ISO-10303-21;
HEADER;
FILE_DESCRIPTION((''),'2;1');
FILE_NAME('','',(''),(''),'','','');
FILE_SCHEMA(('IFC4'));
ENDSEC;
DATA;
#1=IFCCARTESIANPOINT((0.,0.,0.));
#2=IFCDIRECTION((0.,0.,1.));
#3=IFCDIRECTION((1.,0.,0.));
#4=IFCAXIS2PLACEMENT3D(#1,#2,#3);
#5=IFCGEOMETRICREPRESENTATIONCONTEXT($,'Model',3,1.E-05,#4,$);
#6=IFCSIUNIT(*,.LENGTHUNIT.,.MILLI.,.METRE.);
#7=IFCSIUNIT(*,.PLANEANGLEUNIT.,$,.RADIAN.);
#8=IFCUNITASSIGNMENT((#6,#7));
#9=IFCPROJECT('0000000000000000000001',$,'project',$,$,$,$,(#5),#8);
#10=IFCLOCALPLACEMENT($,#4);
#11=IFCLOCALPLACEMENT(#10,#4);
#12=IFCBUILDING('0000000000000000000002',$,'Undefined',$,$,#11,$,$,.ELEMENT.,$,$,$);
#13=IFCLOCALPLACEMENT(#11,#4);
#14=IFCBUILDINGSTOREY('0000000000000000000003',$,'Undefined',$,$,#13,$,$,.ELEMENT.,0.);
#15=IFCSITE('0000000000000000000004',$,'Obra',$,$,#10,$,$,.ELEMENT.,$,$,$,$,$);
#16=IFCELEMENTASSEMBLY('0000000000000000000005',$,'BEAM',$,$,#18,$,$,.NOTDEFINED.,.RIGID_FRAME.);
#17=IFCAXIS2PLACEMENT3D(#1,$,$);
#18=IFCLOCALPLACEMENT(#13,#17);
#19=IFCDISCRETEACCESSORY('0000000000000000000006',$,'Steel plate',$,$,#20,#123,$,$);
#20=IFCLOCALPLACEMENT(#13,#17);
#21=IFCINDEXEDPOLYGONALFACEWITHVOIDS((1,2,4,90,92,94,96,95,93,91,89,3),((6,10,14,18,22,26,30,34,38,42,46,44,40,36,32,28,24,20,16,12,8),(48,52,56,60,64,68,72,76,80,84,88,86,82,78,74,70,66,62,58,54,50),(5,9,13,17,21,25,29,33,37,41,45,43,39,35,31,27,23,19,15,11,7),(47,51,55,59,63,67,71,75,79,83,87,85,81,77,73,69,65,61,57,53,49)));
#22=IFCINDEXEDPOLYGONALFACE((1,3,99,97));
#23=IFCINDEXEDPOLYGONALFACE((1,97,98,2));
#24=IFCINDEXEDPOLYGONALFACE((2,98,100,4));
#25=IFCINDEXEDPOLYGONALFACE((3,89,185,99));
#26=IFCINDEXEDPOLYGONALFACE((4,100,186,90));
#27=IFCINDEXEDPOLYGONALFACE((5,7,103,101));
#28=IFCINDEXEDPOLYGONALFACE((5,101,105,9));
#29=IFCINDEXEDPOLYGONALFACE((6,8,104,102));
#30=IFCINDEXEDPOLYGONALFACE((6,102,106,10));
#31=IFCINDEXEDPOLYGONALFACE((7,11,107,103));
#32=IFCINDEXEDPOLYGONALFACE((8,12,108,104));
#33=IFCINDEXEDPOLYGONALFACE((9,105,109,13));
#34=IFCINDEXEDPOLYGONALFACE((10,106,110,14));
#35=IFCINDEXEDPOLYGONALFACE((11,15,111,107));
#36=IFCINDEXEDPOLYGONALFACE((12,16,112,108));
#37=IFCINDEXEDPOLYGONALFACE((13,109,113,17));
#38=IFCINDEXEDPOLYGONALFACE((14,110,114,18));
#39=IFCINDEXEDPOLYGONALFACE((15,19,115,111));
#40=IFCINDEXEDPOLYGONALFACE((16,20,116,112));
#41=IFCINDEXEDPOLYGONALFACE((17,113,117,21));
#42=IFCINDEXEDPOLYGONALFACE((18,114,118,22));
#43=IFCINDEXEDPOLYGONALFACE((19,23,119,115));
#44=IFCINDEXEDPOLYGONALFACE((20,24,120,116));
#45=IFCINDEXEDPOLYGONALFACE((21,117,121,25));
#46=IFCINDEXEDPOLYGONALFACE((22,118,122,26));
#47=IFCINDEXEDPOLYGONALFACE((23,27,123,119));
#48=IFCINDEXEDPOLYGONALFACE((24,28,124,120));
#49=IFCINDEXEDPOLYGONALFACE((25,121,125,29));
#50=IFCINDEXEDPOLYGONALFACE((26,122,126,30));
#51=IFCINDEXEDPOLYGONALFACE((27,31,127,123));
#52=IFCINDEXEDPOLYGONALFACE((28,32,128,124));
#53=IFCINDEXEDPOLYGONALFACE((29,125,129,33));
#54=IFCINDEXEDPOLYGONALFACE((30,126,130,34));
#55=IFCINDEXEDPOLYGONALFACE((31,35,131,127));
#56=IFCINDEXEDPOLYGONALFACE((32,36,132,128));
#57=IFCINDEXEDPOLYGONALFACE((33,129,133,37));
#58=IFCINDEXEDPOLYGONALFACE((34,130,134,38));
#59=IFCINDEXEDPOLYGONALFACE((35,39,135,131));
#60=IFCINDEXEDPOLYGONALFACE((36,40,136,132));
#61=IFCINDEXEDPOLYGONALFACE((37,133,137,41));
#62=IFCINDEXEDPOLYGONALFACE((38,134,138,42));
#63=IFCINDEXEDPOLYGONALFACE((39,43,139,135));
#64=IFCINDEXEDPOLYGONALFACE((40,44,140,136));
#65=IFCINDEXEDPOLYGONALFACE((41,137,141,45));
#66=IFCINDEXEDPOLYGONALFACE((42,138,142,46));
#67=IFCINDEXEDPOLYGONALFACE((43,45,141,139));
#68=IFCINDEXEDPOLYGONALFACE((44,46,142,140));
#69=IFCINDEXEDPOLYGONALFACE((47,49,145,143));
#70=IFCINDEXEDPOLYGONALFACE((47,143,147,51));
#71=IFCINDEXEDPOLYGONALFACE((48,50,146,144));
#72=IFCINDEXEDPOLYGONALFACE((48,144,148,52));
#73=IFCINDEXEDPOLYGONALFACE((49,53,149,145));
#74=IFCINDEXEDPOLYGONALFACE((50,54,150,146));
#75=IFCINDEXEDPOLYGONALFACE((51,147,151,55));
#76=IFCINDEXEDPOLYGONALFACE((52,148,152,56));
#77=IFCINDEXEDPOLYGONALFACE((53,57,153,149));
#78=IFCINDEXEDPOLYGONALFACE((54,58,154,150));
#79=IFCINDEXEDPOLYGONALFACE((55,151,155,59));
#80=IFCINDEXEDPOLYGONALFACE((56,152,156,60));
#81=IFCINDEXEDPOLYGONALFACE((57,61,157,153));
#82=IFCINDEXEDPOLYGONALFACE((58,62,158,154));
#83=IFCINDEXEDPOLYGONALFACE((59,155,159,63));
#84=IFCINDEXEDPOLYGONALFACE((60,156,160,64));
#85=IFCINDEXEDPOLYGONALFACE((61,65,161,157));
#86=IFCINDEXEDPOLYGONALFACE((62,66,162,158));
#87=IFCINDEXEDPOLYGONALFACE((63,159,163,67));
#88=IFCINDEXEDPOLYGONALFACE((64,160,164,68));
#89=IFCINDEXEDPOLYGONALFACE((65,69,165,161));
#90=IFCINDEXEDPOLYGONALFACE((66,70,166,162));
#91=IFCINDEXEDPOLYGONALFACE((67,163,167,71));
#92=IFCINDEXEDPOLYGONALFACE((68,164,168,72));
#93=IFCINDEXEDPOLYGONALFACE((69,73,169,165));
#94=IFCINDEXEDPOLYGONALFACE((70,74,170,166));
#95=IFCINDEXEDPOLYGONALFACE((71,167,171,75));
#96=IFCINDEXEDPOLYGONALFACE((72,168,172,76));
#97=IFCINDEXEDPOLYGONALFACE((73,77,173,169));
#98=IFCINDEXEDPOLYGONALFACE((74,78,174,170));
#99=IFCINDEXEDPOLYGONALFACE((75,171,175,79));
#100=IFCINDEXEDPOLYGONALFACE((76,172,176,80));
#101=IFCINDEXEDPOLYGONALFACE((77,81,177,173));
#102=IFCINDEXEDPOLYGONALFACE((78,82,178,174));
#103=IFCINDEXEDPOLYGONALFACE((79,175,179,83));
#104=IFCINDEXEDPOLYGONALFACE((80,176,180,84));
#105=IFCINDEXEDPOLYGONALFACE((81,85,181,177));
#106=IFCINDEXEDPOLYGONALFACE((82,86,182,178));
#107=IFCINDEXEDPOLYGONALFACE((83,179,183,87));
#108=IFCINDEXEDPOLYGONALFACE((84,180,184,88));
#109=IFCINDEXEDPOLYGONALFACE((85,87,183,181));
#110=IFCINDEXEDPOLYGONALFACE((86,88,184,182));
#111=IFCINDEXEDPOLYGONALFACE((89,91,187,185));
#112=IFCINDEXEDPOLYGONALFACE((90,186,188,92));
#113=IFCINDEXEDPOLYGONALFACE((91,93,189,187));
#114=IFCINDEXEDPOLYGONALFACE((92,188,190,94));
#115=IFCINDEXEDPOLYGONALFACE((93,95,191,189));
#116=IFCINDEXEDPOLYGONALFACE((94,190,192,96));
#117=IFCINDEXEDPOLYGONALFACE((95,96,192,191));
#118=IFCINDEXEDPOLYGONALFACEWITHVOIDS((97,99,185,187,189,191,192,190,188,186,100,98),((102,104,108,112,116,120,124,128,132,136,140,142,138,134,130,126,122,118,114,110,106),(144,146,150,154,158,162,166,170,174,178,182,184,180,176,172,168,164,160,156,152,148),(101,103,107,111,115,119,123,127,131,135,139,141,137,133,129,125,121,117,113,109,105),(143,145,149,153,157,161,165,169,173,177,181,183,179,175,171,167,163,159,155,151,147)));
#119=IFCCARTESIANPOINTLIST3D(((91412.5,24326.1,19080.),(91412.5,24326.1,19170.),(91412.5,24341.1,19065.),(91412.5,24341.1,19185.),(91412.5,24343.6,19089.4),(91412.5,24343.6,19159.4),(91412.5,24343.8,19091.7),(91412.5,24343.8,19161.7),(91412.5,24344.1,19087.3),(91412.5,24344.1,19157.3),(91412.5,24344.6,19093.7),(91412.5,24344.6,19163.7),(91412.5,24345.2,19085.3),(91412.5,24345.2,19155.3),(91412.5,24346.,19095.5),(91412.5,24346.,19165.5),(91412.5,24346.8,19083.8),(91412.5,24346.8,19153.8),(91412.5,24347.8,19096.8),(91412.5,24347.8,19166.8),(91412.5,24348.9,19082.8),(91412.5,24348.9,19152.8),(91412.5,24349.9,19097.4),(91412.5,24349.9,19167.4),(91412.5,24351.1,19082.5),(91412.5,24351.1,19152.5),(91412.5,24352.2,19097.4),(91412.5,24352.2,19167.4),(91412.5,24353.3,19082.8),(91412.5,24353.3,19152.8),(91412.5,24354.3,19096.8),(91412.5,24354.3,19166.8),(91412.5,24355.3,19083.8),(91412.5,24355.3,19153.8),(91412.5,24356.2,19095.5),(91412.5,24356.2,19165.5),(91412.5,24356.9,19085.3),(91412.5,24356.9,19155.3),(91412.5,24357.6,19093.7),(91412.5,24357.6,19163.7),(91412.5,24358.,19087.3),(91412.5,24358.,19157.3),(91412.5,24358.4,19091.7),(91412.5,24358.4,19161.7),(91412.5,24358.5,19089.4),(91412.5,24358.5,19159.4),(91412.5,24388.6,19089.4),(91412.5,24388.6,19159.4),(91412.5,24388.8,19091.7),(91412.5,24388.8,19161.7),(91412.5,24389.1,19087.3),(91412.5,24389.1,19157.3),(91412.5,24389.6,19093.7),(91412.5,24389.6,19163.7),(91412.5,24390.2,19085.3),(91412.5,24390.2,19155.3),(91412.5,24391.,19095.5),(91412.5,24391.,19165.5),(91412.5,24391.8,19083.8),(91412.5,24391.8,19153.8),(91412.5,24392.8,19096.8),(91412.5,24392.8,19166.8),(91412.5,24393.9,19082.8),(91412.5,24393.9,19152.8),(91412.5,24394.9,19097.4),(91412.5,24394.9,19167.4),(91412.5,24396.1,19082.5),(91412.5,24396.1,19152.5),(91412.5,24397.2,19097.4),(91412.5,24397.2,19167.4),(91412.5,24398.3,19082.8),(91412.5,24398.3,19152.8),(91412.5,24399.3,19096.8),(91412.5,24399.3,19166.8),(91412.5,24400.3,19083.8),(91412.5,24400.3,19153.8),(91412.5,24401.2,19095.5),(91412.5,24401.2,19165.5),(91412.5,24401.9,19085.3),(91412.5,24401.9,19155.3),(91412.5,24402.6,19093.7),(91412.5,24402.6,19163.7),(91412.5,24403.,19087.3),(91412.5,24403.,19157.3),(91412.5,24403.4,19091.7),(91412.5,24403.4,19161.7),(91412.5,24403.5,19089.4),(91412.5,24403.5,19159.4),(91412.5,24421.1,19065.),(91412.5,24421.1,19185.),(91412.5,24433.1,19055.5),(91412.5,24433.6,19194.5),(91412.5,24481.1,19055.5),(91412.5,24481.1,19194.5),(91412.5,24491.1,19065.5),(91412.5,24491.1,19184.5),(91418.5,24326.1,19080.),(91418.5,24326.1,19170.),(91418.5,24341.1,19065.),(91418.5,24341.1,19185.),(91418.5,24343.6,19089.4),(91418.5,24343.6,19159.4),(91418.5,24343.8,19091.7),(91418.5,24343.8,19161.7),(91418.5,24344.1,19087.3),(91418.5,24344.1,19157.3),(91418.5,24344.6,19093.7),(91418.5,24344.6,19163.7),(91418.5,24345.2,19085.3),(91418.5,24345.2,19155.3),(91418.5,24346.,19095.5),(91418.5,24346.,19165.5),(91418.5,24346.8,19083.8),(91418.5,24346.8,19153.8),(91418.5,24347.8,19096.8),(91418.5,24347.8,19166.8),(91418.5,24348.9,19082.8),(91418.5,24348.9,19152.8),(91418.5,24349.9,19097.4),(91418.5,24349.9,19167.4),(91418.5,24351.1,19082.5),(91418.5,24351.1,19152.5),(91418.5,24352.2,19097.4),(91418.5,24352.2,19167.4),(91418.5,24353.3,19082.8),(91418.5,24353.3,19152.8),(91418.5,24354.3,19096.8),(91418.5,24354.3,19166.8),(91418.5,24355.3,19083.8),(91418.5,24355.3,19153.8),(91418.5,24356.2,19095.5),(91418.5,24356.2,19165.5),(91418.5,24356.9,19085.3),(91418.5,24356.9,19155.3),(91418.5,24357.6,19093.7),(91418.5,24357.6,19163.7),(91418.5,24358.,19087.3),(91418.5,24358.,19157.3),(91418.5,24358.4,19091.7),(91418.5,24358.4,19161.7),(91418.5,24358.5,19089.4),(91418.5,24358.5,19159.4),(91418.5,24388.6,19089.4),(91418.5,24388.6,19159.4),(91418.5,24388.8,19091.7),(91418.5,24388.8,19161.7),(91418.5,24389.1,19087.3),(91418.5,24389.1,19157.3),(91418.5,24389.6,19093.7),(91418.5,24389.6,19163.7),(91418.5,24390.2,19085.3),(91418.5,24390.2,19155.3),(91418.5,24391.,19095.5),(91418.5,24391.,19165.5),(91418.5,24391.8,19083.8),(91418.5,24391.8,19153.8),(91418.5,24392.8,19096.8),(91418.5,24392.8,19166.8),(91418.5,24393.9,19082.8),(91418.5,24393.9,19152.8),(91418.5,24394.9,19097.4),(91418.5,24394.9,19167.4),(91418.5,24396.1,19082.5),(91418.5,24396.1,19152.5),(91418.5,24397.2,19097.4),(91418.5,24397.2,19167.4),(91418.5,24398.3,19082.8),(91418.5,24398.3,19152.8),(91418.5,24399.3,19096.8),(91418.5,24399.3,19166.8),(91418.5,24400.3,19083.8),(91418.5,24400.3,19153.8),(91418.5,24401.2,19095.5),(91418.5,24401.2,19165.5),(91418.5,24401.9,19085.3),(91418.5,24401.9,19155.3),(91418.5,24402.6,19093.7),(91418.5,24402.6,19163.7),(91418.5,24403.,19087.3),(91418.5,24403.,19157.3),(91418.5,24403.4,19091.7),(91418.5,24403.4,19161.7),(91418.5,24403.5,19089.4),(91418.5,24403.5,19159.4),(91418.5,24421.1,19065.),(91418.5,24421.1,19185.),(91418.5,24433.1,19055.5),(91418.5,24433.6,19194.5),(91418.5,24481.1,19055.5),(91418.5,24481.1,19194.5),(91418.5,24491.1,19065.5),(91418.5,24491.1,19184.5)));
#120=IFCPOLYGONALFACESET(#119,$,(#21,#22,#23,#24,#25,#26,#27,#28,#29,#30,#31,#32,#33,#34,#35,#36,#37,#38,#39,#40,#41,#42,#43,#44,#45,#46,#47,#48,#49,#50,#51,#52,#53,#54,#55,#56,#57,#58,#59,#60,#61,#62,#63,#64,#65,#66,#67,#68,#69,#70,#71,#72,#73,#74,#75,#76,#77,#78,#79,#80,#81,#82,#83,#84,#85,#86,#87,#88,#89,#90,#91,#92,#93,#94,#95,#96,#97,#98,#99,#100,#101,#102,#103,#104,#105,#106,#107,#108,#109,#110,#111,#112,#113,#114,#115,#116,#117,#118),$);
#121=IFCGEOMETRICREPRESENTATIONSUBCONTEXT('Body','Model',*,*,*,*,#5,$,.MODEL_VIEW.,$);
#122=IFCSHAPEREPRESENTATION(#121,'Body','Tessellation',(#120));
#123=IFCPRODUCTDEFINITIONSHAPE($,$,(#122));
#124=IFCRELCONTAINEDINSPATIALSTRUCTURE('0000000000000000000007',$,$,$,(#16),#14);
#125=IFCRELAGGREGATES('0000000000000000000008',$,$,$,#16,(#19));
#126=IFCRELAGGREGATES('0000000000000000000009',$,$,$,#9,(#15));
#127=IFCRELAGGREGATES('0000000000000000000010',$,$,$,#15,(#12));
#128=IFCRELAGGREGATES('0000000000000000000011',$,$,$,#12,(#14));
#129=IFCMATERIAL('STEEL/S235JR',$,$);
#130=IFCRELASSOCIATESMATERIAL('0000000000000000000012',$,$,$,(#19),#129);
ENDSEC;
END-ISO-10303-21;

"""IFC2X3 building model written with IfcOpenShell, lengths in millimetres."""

from ifc_helpers import new_model, si_unit, frame, origin_with_axes, origin_2d_with_axis, place, context, subcontext, project, spatial, polyline, circle, outline, extrude, source, transform, mapped, material, element, aggregate, save


model = new_model("IFC2X3")

# Units and contexts
model_context = context("Model", 3, precision=1e-05, world=origin_with_axes())
body_context = subcontext(model_context, "Body", "Model", "MODEL_VIEW")
ifc_project = project(units=[si_unit("LENGTHUNIT", "METRE", prefix="MILLI"), si_unit("PLANEANGLEUNIT", "RADIAN")], contexts=[model_context])

# Site, building, storey
site_placement = place(None, origin_with_axes())
site = spatial("IfcSite", under=ifc_project, at=site_placement, Name="Obra", CompositionType="ELEMENT")
building_placement = place(site_placement, origin_with_axes())
building = spatial("IfcBuilding", under=site, at=building_placement, Name="Undefined", CompositionType="ELEMENT")
storey_placement = place(building_placement, origin_with_axes())
storey = spatial("IfcBuildingStorey", under=building, at=storey_placement, Name="Undefined", CompositionType="ELEMENT", Elevation=0.0)

# Shared definitions
ifc_material_1 = material(Name="STEEL/S235JR")

# Element assembly, discrete accessory, opening
assembly_1_placement = place(storey_placement, origin_with_axes())
assembly_1 = element("IfcElementAssembly", 1, at=assembly_1_placement, inside=storey, Name="BEAM", AssemblyPlace="NOTDEFINED", PredefinedType="RIGID_FRAME")
discrete_accessory_1_placement = place(assembly_1_placement, frame((91415.5, 24491.1, 19065.5), z_axis=(-1.0, 0.0, 0.0), x_axis=(0.000001, -0.707107, -0.707107)))
discrete_accessory_1 = element("IfcDiscreteAccessory", 2, at=discrete_accessory_1_placement, material=ifc_material_1, Name="Steel plate", context=body_context, shape_type="SweptSolid", body=[
    extrude(outline(polyline([(0.0, 0.0), (14.1, 0.0), (48.1, 33.9), (49.9, 49.1), (106.4, 105.7), (106.4, 126.9), (42.8, 190.6), (21.6, 190.6), (-35.0, 134.0), (-50.6, 131.9), (-84.1, 98.3), (-84.1, 84.1), (0.0, 0.0)])), frame((0.0, 0.0, -3.0), z_axis=(0.0, 0.0, 1.0), x_axis=(1.0, 0.0, 0.0)), (0.0, 0.0, 1.0), 6.0),
])
shared_shape_1 = source(origin_with_axes(), body_context, "Body", "SweptSolid", [
    extrude(circle(Radius=7.5, at=origin_2d_with_axis()), frame((0.0, 2.4, 0.0), z_axis=(0.0, 1.0, 0.0), x_axis=(1.0, 0.0, 0.0)), (0.0, 0.0, 1.0), 6.2),
])
opening_1_placement = place(assembly_1_placement, frame((91410.0, 24373.6, 19160.0), z_axis=(0.0, -1.0, 0.0), x_axis=(0.0, 0.0, -1.0)))
element("IfcOpeningElement", 3, at=opening_1_placement, cuts=discrete_accessory_1, ObjectType="Opening", context=body_context, shape_type="MappedRepresentation", body=[
    mapped(shared_shape_1, transform((0.0, 0.0, -22.5))),
    mapped(shared_shape_1, transform((70.0, 0.0, -22.5))),
    mapped(shared_shape_1, transform((0.0, 0.0, 22.5))),
    mapped(shared_shape_1, transform((70.0, 0.0, 22.5))),
])

aggregate(assembly_1, [discrete_accessory_1])

save(model, "model.ifc")
